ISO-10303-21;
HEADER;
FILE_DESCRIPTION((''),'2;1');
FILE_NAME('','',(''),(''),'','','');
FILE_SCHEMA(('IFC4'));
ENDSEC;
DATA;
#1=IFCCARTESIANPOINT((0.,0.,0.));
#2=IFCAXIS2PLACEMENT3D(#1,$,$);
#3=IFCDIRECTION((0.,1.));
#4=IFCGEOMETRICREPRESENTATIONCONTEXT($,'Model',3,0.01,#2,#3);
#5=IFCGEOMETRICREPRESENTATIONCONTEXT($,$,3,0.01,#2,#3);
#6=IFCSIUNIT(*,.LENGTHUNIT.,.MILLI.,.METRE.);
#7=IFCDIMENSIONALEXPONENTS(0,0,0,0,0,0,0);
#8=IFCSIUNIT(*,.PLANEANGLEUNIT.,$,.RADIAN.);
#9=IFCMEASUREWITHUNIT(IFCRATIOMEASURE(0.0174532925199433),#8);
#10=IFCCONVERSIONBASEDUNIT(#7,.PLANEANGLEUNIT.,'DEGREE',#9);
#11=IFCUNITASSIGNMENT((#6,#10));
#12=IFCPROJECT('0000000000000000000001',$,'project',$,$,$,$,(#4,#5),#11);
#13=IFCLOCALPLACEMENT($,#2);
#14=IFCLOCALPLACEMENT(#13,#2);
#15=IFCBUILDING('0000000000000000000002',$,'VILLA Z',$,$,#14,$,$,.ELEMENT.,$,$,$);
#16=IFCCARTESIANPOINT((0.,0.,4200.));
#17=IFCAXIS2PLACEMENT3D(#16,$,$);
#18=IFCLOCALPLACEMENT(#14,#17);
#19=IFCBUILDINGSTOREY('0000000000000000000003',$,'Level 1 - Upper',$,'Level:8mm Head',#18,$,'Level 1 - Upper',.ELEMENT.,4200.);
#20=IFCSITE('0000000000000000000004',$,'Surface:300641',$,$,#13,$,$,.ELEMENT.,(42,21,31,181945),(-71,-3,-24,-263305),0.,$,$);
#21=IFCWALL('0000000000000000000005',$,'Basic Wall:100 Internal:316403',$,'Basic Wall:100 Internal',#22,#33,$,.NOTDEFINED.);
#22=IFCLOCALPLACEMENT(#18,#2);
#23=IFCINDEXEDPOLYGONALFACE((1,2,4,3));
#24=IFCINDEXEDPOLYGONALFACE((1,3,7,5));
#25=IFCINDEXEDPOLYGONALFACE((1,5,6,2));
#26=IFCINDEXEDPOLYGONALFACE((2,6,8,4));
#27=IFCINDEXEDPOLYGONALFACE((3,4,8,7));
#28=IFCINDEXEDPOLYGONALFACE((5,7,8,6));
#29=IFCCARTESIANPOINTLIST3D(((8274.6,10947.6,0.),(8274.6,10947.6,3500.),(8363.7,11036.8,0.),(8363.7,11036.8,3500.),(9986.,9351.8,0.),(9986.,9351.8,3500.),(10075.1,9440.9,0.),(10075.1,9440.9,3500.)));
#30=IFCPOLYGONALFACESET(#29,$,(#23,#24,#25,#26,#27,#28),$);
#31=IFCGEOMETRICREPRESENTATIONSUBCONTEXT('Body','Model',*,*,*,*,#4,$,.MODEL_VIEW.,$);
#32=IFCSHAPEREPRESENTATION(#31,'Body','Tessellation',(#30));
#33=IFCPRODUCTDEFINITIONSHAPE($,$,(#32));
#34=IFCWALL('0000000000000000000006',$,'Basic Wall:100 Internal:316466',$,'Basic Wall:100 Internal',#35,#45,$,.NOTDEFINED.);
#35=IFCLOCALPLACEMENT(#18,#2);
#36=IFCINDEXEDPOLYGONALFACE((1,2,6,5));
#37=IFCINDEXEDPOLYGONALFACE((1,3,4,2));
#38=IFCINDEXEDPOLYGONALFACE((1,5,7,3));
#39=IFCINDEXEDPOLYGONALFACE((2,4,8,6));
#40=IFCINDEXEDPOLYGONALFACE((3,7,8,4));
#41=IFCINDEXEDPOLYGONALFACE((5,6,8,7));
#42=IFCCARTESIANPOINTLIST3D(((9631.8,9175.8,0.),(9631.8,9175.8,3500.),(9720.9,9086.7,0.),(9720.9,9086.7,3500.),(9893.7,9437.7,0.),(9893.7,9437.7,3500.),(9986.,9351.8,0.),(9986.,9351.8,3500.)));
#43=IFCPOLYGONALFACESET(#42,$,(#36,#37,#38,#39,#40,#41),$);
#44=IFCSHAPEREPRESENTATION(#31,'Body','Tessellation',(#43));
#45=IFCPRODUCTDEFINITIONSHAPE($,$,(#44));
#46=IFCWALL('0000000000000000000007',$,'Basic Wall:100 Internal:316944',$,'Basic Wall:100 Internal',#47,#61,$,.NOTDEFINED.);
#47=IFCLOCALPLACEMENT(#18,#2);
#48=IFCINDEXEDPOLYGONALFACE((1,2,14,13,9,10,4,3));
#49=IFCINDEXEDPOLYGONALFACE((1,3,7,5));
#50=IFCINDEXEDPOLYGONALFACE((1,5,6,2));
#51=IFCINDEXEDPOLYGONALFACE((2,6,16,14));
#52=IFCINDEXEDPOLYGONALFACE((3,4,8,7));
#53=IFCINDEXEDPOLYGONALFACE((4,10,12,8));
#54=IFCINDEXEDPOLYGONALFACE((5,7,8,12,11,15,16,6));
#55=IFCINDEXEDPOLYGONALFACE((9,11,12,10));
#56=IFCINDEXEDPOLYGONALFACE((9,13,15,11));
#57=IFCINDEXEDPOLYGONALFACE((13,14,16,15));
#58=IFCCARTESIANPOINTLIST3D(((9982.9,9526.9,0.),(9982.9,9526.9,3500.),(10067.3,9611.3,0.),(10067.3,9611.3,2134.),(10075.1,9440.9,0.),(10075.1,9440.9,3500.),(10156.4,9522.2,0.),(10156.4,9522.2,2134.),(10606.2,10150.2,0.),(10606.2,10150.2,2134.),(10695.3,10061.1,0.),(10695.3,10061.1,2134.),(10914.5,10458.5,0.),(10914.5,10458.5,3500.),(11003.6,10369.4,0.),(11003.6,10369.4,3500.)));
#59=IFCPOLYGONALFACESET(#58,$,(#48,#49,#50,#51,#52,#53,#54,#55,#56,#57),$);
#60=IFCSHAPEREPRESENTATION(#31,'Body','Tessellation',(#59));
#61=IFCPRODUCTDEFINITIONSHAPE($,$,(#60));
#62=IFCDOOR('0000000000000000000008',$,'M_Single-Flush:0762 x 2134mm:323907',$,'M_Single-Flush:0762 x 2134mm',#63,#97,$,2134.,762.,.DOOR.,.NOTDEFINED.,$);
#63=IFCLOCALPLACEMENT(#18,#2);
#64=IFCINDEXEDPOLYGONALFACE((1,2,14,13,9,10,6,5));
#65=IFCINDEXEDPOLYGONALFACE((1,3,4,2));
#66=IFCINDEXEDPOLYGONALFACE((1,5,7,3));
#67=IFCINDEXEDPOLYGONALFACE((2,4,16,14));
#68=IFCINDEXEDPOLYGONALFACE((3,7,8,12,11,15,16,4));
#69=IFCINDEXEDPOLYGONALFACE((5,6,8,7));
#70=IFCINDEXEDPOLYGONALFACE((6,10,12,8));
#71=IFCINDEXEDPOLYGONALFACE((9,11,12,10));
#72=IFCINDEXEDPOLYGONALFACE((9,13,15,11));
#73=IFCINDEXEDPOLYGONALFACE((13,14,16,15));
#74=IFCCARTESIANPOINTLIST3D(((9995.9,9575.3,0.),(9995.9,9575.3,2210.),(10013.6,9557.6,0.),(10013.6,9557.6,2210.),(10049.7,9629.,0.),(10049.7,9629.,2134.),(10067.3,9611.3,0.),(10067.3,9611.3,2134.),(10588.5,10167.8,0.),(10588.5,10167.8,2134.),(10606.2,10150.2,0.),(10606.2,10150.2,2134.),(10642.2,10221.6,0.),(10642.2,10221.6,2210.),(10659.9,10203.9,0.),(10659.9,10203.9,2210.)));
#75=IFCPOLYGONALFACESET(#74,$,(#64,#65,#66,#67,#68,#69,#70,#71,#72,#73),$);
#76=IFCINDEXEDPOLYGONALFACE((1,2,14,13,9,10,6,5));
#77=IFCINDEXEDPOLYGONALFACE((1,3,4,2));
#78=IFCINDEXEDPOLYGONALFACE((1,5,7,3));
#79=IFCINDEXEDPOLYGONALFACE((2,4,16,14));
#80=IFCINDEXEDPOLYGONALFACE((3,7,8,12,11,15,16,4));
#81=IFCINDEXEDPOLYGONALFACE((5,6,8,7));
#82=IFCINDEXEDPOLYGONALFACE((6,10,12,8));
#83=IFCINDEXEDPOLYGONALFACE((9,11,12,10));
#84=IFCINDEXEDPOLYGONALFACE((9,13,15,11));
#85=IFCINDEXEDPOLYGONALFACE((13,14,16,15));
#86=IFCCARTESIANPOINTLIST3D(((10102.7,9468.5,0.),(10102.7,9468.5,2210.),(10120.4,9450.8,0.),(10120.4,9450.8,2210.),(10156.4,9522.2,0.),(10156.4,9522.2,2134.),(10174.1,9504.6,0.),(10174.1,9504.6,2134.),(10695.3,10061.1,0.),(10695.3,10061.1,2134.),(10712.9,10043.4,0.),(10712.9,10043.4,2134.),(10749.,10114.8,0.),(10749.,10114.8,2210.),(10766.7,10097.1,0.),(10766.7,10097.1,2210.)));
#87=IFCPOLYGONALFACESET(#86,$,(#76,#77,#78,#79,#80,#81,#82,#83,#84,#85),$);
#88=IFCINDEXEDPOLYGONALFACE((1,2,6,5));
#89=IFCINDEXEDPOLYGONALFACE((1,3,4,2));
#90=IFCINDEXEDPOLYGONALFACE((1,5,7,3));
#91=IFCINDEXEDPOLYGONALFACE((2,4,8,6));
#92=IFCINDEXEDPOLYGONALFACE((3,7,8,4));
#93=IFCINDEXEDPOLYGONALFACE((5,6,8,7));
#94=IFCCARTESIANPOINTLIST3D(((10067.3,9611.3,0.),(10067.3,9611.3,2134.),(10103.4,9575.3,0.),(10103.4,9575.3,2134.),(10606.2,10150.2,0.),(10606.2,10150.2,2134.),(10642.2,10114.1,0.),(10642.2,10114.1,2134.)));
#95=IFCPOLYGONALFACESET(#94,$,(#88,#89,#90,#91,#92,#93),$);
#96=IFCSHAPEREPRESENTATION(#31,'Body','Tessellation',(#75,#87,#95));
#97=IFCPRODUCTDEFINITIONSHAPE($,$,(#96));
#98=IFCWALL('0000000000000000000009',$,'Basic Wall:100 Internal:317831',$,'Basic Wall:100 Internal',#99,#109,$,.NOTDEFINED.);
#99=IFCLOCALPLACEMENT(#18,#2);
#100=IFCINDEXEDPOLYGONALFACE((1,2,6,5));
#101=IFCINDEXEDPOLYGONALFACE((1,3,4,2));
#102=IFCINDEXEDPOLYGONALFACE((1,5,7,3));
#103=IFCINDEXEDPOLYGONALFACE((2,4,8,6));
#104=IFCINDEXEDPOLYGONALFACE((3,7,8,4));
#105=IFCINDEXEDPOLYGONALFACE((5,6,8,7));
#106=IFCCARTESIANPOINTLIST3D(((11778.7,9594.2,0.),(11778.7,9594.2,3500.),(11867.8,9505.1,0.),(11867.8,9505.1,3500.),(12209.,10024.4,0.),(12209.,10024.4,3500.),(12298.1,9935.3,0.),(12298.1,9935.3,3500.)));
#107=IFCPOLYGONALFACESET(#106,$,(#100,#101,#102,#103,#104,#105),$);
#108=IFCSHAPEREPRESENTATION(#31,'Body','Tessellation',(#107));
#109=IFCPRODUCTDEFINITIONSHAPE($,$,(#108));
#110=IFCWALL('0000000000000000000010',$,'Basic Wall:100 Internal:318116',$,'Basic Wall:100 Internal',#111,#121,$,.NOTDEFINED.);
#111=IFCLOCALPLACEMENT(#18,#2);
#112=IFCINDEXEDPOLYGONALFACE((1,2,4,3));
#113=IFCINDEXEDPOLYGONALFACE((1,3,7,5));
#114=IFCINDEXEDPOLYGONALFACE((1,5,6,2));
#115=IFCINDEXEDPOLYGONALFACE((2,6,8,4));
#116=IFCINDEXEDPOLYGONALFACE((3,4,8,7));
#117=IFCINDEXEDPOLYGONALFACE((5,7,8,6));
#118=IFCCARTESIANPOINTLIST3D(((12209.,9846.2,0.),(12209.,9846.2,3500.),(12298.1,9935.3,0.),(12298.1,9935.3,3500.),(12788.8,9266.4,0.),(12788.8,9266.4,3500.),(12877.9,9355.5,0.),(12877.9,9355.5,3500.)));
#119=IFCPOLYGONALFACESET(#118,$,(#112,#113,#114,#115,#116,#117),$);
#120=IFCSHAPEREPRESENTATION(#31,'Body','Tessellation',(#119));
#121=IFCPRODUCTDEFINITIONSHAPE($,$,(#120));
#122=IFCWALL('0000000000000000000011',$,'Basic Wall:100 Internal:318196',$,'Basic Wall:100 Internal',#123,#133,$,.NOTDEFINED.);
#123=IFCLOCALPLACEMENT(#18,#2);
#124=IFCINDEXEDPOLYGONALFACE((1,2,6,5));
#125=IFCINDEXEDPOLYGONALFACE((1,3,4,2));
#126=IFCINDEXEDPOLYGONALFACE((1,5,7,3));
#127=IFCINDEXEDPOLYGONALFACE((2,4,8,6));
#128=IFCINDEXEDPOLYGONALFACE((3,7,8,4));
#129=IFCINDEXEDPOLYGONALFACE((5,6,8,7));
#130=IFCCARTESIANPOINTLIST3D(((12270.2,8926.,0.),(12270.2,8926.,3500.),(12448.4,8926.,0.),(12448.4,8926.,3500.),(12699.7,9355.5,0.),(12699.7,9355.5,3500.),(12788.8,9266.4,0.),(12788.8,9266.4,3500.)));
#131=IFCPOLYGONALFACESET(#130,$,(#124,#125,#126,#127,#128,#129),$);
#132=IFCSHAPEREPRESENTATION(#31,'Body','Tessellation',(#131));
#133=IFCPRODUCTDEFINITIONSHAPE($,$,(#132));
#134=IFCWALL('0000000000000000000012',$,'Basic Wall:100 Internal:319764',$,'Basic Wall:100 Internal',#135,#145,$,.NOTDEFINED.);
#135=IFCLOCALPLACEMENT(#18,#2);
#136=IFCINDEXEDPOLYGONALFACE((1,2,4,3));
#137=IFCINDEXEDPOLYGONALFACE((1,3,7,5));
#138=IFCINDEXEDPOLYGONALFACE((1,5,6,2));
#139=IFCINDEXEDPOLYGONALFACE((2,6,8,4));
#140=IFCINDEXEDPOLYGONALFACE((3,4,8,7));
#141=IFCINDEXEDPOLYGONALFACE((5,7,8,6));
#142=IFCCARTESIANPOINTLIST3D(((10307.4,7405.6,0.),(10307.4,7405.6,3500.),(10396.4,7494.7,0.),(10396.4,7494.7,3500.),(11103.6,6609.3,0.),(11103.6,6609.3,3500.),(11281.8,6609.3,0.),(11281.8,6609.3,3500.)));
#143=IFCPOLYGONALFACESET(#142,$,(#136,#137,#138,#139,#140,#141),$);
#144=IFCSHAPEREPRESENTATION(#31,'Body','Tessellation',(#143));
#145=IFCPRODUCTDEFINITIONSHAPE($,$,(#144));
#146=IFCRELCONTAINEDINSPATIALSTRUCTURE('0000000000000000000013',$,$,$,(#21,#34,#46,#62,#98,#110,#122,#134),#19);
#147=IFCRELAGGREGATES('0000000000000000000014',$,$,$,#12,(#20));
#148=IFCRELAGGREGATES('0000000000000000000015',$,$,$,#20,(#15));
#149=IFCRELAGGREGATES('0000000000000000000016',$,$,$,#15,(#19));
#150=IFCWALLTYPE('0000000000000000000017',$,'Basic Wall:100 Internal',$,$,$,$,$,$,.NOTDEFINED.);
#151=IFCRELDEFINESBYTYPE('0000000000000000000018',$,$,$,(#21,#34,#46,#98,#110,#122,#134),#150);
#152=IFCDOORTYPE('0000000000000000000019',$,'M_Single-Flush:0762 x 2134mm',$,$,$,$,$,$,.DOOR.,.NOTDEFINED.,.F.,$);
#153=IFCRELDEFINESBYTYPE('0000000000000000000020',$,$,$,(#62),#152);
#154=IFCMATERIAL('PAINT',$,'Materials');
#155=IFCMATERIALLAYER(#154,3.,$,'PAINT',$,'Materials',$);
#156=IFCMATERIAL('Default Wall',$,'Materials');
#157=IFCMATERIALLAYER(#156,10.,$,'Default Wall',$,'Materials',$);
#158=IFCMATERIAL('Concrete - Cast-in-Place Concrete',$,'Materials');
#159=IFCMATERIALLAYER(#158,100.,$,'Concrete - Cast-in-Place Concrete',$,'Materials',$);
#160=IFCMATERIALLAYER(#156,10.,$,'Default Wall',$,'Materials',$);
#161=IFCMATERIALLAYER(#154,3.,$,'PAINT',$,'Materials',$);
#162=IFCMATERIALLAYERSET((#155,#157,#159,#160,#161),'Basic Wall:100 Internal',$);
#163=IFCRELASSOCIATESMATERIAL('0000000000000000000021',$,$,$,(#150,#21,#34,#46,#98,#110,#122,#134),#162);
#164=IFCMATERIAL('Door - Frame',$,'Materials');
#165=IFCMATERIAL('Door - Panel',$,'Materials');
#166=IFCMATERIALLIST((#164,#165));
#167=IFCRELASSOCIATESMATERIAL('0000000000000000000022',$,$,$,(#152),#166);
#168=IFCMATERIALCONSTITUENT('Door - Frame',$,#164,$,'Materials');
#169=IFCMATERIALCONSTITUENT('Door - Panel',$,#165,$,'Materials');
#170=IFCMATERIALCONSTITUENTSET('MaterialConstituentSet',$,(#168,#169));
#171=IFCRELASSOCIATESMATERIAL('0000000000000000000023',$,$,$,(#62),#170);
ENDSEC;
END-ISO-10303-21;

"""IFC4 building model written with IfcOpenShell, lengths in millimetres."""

from ifc_helpers import new_model, entity, si_unit, converted_unit, direction, frame, frame_2d, origin, place, context, subcontext, project, spatial, polyline, rectangle, outline, extrude, clip, halfspace, source, transform, mapped, material, material_list, layer, layer_set, layer_usage, constituent, constituent_set, type_object, type_shapes, element, fill, save


model = new_model("IFC4")

# Units and contexts
model_context = context("Model", 3, precision=0.01, world=origin(), true_north=direction((0.0, 1.0)))
context_of_model = context(None, 3, precision=0.01, world=origin(), true_north=direction((0.0, 1.0)))
body_context = subcontext(model_context, "Body", "Model", "MODEL_VIEW")
ifc_project = project(units=[si_unit("LENGTHUNIT", "METRE", prefix="MILLI"), converted_unit("PLANEANGLEUNIT", "DEGREE", entity("IfcRatioMeasure", 0.0174532925199433), si_unit("PLANEANGLEUNIT", "RADIAN"), dimensions=[0, 0, 0, 0, 0, 0, 0])], contexts=[model_context, context_of_model])

# Site, building, storey
site_placement = place(None, origin())
site = spatial("IfcSite", under=ifc_project, at=site_placement, Name="Surface:300641", CompositionType="ELEMENT", RefLatitude=(42, 21, 31, 181945), RefLongitude=(-71, -3, -24, -263305), RefElevation=0.0)
building_placement = place(site_placement, origin())
building = spatial("IfcBuilding", under=site, at=building_placement, Name="VILLA Z", CompositionType="ELEMENT")
storey_placement = place(building_placement, frame((0.0, 0.0, 4200.0)))
storey = spatial("IfcBuildingStorey", under=building, at=storey_placement, Name="Level 1 - Upper", ObjectType="Level:8mm Head", LongName="Level 1 - Upper", CompositionType="ELEMENT", Elevation=4200.0)

# Shared definitions
ifc_material_1 = material(Name="PAINT", Category="Materials")
ifc_material_2 = material(Name="Concrete - Cast-in-Place Concrete", Category="Materials")
ifc_material_3 = material(Name="Default Wall", Category="Materials")

# Shared definitions
ifc_layer_1 = layer(ifc_material_1, 3.0, Name="PAINT", Category="Materials")
ifc_layer_2 = layer(ifc_material_3, 10.0, Name="Default Wall", Category="Materials")
ifc_layer_3 = layer(ifc_material_2, 100.0, Name="Concrete - Cast-in-Place Concrete", Category="Materials")
ifc_layer_4 = layer(ifc_material_3, 10.0, Name="Default Wall", Category="Materials")
ifc_layer_5 = layer(ifc_material_1, 3.0, Name="PAINT", Category="Materials")
ifc_layer_set_1 = layer_set([ifc_layer_1, ifc_layer_2, ifc_layer_3, ifc_layer_4, ifc_layer_5], Name="Basic Wall:100 Internal")
wall_type_1 = type_object("IfcWallType", Name="Basic Wall:100 Internal", PredefinedType="NOTDEFINED", material=ifc_layer_set_1)

# Shared definitions
ifc_material_4 = material(Name="Door - Frame", Category="Materials")
ifc_material_5 = material(Name="Door - Panel", Category="Materials")
ifc_material_list = material_list([ifc_material_4, ifc_material_5])
door_type = type_object("IfcDoorType", Name="M_Single-Flush:0762 x 2134mm", OperationType="NOTDEFINED", ParameterTakesPrecedence=False, PredefinedType="DOOR", material=ifc_material_list)
shared_shape_1 = source(origin(), body_context, "Body", "SweptSolid", [
    extrude(outline(polyline([(-457.0, -1124.0), (457.0, -1124.0), (457.0, 1086.0), (381.0, 1086.0), (381.0, -1048.0), (-381.0, -1048.0), (-381.0, 1086.0), (-457.0, 1086.0), (-457.0, -1124.0)])), frame((381.0, 151.0, 1086.0), z_axis=(0.0, -1.0, 0.0), x_axis=(-1.0, 0.0, 0.0)), (0.0, 0.0, 1.0), 25.0),
    extrude(outline(polyline([(-1124.0, -457.0), (1086.0, -457.0), (1086.0, -381.0), (-1048.0, -381.0), (-1048.0, 381.0), (1086.0, 381.0), (1086.0, 457.0), (-1124.0, 457.0), (-1124.0, -457.0)])), frame((381.0, 0.0, 1086.0), z_axis=(0.0, -1.0, 0.0), x_axis=(0.0, 0.0, -1.0)), (0.0, 0.0, 1.0), 25.0),
    extrude(rectangle(XDim=762.0, YDim=51.0, at=frame_2d((0.0, 0.0), x_axis=(1.0, 0.0))), frame((381.0, 100.5, 0.0)), (0.0, 0.0, 1.0), 2134.0),
])
type_shapes(door_type, [shared_shape_1])

# Walls
ifc_layer_usage_1 = layer_usage(ifc_layer_set_1, "AXIS2", "NEGATIVE", 63.0)
wall_1_placement = place(storey_placement, frame((8317.6, 10993.7, 0.0), z_axis=(0.0, 0.0, 1.0), x_axis=(0.731354, -0.681998, 0.0)))
element("IfcWall", 1, at=wall_1_placement, inside=storey, type_object=wall_type_1, material=ifc_layer_usage_1, Name="Basic Wall:100 Internal:316403", ObjectType="Basic Wall:100 Internal", PredefinedType="NOTDEFINED", context=body_context, shape_type="Clipping", body=[
    clip(extrude(outline(polyline([(2340.0, -63.0), (2344.4, 63.0), (2218.3, 63.0), (4.4, 63.0), (0.0, -63.0), (2213.9, -63.0), (2340.0, -63.0)])), origin(), (0.0, 0.0, 1.0), 3500.0), halfspace(origin(), True)),
])
ifc_layer_usage_2 = layer_usage(ifc_layer_set_1, "AXIS2", "NEGATIVE", 63.0)
wall_2_placement = place(storey_placement, frame((9941.4, 9396.3, 0.0), z_axis=(0.0, 0.0, 1.0), x_axis=(-0.707107, -0.707107, 0.0)))
element("IfcWall", 2, at=wall_2_placement, inside=storey, type_object=wall_type_1, material=ifc_layer_usage_2, Name="Basic Wall:100 Internal:316466", ObjectType="Basic Wall:100 Internal", PredefinedType="NOTDEFINED", context=body_context, shape_type="Clipping", body=[
    clip(extrude(outline(polyline([(374.9, -63.0), (374.9, 63.0), (0.0, 63.0), (4.4, -63.0), (374.9, -63.0)])), origin(), (0.0, 0.0, 1.0), 3500.0), halfspace(origin(), True)),
])

# Wall, opening, door
ifc_layer_usage_3 = layer_usage(ifc_layer_set_1, "AXIS2", "NEGATIVE", 63.0)
wall_3_placement = place(storey_placement, frame((10959.0, 10413.9, 0.0), z_axis=(0.0, 0.0, 1.0), x_axis=(-0.707107, -0.707107, 0.0)))
wall_3 = element("IfcWall", 3, at=wall_3_placement, inside=storey, type_object=wall_type_1, material=ifc_layer_usage_3, Name="Basic Wall:100 Internal:316944", ObjectType="Basic Wall:100 Internal", PredefinedType="NOTDEFINED", context=body_context, shape_type="Clipping", body=[
    clip(extrude(outline(polyline([(0.0, -63.0), (254.0, -63.0), (380.0, -63.0), (1317.4, -63.0), (1313.0, 63.0), (0.0, 63.0), (0.0, -63.0)])), origin(), (0.0, 0.0, 1.0), 3500.0), halfspace(origin(), True)),
])
opening_1_placement = place(wall_3_placement, frame((1198.0, 63.0, 0.0)))
opening_1 = element("IfcOpeningElement", 4, at=opening_1_placement, cuts=wall_3, ObjectType="Opening", PredefinedType="OPENING", context=body_context, shape_type="SweptSolid", body=[
    extrude(rectangle(XDim=762.0, YDim=2134.0, at=frame_2d((1067.0, 381.0), x_axis=(0.0, -1.0))), frame((0.0, 0.0, 0.0), z_axis=(0.0, -1.0, 0.0), x_axis=(0.0, 0.0, 1.0)), (0.0, 0.0, 1.0), 126.0),
])
ifc_constituent_1 = constituent(ifc_material_4, Name="Door - Frame", Category="Materials")
ifc_constituent_2 = constituent(ifc_material_5, Name="Door - Panel", Category="Materials")
ifc_constituent_set_1 = constituent_set(constituents=[ifc_constituent_1, ifc_constituent_2], Name="MaterialConstituentSet")
door_1_placement = place(opening_1_placement, frame((0.0, 0.0, 0.0), z_axis=(0.0, 0.0, 1.0), x_axis=(-1.0, 0.0, 0.0)))
door_1 = element("IfcDoor", 5, at=door_1_placement, inside=storey, type_object=door_type, material=ifc_constituent_set_1, Name="M_Single-Flush:0762 x 2134mm:323907", ObjectType="M_Single-Flush:0762 x 2134mm", OperationType="NOTDEFINED", OverallHeight=2134.0, OverallWidth=762.0, PredefinedType="DOOR", context=body_context, shape_type="MappedRepresentation", body=[
    mapped(shared_shape_1, transform((0.0, 0.0, 0.0), scale=1.0)),
])
fill(opening_1, door_1)

# Walls
ifc_layer_usage_4 = layer_usage(ifc_layer_set_1, "AXIS2", "NEGATIVE", 63.0)
wall_4_placement = place(storey_placement, frame((11823.3, 9549.6, 0.0), z_axis=(0.0, 0.0, 1.0), x_axis=(0.707107, 0.707107, 0.0)))
element("IfcWall", 6, at=wall_4_placement, inside=storey, type_object=wall_type_1, material=ifc_layer_usage_4, Name="Basic Wall:100 Internal:317831", ObjectType="Basic Wall:100 Internal", PredefinedType="NOTDEFINED", context=body_context, shape_type="Clipping", body=[
    clip(extrude(rectangle(XDim=608.4, YDim=126.0, at=frame_2d((304.2, 0.0), x_axis=(-1.0, 0.0))), origin(), (0.0, 0.0, 1.0), 3500.0), halfspace(origin(), True)),
])
ifc_layer_usage_5 = layer_usage(ifc_layer_set_1, "AXIS2", "NEGATIVE", 63.0)
wall_5_placement = place(storey_placement, frame((12253.5, 9890.7, 0.0), z_axis=(0.0, 0.0, 1.0), x_axis=(0.707107, -0.707107, 0.0)))
element("IfcWall", 7, at=wall_5_placement, inside=storey, type_object=wall_type_1, material=ifc_layer_usage_5, Name="Basic Wall:100 Internal:318116", ObjectType="Basic Wall:100 Internal", PredefinedType="NOTDEFINED", context=body_context, shape_type="Clipping", body=[
    clip(extrude(rectangle(XDim=820.0, YDim=126.0, at=frame_2d((410.0, 0.0), x_axis=(-1.0, 0.0))), origin(), (0.0, 0.0, 1.0), 3500.0), halfspace(origin(), True)),
])
ifc_layer_usage_6 = layer_usage(ifc_layer_set_1, "AXIS2", "NEGATIVE", 63.0)
wall_6_placement = place(storey_placement, frame((12744.2, 9310.9, 0.0), z_axis=(0.0, 0.0, 1.0), x_axis=(-0.707107, -0.707107, 0.0)))
element("IfcWall", 8, at=wall_6_placement, inside=storey, type_object=wall_type_1, material=ifc_layer_usage_6, Name="Basic Wall:100 Internal:318196", ObjectType="Basic Wall:100 Internal", PredefinedType="NOTDEFINED", context=body_context, shape_type="Clipping", body=[
    clip(extrude(outline(polyline([(607.4, -63.0), (545.3, -0.9), (481.4, 63.0), (0.0, 63.0), (0.0, -63.0), (607.4, -63.0)])), origin(), (0.0, 0.0, 1.0), 3500.0), halfspace(origin(), True)),
])
ifc_layer_usage_7 = layer_usage(ifc_layer_set_1, "AXIS2", "NEGATIVE", 63.0)
wall_7_placement = place(storey_placement, frame((10351.9, 7450.1, 0.0), z_axis=(0.0, 0.0, 1.0), x_axis=(0.707107, -0.707107, 0.0)))
element("IfcWall", 9, at=wall_7_placement, inside=storey, type_object=wall_type_1, material=ifc_layer_usage_7, Name="Basic Wall:100 Internal:319764", ObjectType="Basic Wall:100 Internal", PredefinedType="NOTDEFINED", context=body_context, shape_type="Clipping", body=[
    clip(extrude(outline(polyline([(1126.1, -63.0), (1252.1, 63.0), (1073.9, 63.0), (0.0, 63.0), (0.0, -63.0), (1126.1, -63.0)])), origin(), (0.0, 0.0, 1.0), 3500.0), halfspace(origin(), True)),
])

save(model, "model.ifc")
